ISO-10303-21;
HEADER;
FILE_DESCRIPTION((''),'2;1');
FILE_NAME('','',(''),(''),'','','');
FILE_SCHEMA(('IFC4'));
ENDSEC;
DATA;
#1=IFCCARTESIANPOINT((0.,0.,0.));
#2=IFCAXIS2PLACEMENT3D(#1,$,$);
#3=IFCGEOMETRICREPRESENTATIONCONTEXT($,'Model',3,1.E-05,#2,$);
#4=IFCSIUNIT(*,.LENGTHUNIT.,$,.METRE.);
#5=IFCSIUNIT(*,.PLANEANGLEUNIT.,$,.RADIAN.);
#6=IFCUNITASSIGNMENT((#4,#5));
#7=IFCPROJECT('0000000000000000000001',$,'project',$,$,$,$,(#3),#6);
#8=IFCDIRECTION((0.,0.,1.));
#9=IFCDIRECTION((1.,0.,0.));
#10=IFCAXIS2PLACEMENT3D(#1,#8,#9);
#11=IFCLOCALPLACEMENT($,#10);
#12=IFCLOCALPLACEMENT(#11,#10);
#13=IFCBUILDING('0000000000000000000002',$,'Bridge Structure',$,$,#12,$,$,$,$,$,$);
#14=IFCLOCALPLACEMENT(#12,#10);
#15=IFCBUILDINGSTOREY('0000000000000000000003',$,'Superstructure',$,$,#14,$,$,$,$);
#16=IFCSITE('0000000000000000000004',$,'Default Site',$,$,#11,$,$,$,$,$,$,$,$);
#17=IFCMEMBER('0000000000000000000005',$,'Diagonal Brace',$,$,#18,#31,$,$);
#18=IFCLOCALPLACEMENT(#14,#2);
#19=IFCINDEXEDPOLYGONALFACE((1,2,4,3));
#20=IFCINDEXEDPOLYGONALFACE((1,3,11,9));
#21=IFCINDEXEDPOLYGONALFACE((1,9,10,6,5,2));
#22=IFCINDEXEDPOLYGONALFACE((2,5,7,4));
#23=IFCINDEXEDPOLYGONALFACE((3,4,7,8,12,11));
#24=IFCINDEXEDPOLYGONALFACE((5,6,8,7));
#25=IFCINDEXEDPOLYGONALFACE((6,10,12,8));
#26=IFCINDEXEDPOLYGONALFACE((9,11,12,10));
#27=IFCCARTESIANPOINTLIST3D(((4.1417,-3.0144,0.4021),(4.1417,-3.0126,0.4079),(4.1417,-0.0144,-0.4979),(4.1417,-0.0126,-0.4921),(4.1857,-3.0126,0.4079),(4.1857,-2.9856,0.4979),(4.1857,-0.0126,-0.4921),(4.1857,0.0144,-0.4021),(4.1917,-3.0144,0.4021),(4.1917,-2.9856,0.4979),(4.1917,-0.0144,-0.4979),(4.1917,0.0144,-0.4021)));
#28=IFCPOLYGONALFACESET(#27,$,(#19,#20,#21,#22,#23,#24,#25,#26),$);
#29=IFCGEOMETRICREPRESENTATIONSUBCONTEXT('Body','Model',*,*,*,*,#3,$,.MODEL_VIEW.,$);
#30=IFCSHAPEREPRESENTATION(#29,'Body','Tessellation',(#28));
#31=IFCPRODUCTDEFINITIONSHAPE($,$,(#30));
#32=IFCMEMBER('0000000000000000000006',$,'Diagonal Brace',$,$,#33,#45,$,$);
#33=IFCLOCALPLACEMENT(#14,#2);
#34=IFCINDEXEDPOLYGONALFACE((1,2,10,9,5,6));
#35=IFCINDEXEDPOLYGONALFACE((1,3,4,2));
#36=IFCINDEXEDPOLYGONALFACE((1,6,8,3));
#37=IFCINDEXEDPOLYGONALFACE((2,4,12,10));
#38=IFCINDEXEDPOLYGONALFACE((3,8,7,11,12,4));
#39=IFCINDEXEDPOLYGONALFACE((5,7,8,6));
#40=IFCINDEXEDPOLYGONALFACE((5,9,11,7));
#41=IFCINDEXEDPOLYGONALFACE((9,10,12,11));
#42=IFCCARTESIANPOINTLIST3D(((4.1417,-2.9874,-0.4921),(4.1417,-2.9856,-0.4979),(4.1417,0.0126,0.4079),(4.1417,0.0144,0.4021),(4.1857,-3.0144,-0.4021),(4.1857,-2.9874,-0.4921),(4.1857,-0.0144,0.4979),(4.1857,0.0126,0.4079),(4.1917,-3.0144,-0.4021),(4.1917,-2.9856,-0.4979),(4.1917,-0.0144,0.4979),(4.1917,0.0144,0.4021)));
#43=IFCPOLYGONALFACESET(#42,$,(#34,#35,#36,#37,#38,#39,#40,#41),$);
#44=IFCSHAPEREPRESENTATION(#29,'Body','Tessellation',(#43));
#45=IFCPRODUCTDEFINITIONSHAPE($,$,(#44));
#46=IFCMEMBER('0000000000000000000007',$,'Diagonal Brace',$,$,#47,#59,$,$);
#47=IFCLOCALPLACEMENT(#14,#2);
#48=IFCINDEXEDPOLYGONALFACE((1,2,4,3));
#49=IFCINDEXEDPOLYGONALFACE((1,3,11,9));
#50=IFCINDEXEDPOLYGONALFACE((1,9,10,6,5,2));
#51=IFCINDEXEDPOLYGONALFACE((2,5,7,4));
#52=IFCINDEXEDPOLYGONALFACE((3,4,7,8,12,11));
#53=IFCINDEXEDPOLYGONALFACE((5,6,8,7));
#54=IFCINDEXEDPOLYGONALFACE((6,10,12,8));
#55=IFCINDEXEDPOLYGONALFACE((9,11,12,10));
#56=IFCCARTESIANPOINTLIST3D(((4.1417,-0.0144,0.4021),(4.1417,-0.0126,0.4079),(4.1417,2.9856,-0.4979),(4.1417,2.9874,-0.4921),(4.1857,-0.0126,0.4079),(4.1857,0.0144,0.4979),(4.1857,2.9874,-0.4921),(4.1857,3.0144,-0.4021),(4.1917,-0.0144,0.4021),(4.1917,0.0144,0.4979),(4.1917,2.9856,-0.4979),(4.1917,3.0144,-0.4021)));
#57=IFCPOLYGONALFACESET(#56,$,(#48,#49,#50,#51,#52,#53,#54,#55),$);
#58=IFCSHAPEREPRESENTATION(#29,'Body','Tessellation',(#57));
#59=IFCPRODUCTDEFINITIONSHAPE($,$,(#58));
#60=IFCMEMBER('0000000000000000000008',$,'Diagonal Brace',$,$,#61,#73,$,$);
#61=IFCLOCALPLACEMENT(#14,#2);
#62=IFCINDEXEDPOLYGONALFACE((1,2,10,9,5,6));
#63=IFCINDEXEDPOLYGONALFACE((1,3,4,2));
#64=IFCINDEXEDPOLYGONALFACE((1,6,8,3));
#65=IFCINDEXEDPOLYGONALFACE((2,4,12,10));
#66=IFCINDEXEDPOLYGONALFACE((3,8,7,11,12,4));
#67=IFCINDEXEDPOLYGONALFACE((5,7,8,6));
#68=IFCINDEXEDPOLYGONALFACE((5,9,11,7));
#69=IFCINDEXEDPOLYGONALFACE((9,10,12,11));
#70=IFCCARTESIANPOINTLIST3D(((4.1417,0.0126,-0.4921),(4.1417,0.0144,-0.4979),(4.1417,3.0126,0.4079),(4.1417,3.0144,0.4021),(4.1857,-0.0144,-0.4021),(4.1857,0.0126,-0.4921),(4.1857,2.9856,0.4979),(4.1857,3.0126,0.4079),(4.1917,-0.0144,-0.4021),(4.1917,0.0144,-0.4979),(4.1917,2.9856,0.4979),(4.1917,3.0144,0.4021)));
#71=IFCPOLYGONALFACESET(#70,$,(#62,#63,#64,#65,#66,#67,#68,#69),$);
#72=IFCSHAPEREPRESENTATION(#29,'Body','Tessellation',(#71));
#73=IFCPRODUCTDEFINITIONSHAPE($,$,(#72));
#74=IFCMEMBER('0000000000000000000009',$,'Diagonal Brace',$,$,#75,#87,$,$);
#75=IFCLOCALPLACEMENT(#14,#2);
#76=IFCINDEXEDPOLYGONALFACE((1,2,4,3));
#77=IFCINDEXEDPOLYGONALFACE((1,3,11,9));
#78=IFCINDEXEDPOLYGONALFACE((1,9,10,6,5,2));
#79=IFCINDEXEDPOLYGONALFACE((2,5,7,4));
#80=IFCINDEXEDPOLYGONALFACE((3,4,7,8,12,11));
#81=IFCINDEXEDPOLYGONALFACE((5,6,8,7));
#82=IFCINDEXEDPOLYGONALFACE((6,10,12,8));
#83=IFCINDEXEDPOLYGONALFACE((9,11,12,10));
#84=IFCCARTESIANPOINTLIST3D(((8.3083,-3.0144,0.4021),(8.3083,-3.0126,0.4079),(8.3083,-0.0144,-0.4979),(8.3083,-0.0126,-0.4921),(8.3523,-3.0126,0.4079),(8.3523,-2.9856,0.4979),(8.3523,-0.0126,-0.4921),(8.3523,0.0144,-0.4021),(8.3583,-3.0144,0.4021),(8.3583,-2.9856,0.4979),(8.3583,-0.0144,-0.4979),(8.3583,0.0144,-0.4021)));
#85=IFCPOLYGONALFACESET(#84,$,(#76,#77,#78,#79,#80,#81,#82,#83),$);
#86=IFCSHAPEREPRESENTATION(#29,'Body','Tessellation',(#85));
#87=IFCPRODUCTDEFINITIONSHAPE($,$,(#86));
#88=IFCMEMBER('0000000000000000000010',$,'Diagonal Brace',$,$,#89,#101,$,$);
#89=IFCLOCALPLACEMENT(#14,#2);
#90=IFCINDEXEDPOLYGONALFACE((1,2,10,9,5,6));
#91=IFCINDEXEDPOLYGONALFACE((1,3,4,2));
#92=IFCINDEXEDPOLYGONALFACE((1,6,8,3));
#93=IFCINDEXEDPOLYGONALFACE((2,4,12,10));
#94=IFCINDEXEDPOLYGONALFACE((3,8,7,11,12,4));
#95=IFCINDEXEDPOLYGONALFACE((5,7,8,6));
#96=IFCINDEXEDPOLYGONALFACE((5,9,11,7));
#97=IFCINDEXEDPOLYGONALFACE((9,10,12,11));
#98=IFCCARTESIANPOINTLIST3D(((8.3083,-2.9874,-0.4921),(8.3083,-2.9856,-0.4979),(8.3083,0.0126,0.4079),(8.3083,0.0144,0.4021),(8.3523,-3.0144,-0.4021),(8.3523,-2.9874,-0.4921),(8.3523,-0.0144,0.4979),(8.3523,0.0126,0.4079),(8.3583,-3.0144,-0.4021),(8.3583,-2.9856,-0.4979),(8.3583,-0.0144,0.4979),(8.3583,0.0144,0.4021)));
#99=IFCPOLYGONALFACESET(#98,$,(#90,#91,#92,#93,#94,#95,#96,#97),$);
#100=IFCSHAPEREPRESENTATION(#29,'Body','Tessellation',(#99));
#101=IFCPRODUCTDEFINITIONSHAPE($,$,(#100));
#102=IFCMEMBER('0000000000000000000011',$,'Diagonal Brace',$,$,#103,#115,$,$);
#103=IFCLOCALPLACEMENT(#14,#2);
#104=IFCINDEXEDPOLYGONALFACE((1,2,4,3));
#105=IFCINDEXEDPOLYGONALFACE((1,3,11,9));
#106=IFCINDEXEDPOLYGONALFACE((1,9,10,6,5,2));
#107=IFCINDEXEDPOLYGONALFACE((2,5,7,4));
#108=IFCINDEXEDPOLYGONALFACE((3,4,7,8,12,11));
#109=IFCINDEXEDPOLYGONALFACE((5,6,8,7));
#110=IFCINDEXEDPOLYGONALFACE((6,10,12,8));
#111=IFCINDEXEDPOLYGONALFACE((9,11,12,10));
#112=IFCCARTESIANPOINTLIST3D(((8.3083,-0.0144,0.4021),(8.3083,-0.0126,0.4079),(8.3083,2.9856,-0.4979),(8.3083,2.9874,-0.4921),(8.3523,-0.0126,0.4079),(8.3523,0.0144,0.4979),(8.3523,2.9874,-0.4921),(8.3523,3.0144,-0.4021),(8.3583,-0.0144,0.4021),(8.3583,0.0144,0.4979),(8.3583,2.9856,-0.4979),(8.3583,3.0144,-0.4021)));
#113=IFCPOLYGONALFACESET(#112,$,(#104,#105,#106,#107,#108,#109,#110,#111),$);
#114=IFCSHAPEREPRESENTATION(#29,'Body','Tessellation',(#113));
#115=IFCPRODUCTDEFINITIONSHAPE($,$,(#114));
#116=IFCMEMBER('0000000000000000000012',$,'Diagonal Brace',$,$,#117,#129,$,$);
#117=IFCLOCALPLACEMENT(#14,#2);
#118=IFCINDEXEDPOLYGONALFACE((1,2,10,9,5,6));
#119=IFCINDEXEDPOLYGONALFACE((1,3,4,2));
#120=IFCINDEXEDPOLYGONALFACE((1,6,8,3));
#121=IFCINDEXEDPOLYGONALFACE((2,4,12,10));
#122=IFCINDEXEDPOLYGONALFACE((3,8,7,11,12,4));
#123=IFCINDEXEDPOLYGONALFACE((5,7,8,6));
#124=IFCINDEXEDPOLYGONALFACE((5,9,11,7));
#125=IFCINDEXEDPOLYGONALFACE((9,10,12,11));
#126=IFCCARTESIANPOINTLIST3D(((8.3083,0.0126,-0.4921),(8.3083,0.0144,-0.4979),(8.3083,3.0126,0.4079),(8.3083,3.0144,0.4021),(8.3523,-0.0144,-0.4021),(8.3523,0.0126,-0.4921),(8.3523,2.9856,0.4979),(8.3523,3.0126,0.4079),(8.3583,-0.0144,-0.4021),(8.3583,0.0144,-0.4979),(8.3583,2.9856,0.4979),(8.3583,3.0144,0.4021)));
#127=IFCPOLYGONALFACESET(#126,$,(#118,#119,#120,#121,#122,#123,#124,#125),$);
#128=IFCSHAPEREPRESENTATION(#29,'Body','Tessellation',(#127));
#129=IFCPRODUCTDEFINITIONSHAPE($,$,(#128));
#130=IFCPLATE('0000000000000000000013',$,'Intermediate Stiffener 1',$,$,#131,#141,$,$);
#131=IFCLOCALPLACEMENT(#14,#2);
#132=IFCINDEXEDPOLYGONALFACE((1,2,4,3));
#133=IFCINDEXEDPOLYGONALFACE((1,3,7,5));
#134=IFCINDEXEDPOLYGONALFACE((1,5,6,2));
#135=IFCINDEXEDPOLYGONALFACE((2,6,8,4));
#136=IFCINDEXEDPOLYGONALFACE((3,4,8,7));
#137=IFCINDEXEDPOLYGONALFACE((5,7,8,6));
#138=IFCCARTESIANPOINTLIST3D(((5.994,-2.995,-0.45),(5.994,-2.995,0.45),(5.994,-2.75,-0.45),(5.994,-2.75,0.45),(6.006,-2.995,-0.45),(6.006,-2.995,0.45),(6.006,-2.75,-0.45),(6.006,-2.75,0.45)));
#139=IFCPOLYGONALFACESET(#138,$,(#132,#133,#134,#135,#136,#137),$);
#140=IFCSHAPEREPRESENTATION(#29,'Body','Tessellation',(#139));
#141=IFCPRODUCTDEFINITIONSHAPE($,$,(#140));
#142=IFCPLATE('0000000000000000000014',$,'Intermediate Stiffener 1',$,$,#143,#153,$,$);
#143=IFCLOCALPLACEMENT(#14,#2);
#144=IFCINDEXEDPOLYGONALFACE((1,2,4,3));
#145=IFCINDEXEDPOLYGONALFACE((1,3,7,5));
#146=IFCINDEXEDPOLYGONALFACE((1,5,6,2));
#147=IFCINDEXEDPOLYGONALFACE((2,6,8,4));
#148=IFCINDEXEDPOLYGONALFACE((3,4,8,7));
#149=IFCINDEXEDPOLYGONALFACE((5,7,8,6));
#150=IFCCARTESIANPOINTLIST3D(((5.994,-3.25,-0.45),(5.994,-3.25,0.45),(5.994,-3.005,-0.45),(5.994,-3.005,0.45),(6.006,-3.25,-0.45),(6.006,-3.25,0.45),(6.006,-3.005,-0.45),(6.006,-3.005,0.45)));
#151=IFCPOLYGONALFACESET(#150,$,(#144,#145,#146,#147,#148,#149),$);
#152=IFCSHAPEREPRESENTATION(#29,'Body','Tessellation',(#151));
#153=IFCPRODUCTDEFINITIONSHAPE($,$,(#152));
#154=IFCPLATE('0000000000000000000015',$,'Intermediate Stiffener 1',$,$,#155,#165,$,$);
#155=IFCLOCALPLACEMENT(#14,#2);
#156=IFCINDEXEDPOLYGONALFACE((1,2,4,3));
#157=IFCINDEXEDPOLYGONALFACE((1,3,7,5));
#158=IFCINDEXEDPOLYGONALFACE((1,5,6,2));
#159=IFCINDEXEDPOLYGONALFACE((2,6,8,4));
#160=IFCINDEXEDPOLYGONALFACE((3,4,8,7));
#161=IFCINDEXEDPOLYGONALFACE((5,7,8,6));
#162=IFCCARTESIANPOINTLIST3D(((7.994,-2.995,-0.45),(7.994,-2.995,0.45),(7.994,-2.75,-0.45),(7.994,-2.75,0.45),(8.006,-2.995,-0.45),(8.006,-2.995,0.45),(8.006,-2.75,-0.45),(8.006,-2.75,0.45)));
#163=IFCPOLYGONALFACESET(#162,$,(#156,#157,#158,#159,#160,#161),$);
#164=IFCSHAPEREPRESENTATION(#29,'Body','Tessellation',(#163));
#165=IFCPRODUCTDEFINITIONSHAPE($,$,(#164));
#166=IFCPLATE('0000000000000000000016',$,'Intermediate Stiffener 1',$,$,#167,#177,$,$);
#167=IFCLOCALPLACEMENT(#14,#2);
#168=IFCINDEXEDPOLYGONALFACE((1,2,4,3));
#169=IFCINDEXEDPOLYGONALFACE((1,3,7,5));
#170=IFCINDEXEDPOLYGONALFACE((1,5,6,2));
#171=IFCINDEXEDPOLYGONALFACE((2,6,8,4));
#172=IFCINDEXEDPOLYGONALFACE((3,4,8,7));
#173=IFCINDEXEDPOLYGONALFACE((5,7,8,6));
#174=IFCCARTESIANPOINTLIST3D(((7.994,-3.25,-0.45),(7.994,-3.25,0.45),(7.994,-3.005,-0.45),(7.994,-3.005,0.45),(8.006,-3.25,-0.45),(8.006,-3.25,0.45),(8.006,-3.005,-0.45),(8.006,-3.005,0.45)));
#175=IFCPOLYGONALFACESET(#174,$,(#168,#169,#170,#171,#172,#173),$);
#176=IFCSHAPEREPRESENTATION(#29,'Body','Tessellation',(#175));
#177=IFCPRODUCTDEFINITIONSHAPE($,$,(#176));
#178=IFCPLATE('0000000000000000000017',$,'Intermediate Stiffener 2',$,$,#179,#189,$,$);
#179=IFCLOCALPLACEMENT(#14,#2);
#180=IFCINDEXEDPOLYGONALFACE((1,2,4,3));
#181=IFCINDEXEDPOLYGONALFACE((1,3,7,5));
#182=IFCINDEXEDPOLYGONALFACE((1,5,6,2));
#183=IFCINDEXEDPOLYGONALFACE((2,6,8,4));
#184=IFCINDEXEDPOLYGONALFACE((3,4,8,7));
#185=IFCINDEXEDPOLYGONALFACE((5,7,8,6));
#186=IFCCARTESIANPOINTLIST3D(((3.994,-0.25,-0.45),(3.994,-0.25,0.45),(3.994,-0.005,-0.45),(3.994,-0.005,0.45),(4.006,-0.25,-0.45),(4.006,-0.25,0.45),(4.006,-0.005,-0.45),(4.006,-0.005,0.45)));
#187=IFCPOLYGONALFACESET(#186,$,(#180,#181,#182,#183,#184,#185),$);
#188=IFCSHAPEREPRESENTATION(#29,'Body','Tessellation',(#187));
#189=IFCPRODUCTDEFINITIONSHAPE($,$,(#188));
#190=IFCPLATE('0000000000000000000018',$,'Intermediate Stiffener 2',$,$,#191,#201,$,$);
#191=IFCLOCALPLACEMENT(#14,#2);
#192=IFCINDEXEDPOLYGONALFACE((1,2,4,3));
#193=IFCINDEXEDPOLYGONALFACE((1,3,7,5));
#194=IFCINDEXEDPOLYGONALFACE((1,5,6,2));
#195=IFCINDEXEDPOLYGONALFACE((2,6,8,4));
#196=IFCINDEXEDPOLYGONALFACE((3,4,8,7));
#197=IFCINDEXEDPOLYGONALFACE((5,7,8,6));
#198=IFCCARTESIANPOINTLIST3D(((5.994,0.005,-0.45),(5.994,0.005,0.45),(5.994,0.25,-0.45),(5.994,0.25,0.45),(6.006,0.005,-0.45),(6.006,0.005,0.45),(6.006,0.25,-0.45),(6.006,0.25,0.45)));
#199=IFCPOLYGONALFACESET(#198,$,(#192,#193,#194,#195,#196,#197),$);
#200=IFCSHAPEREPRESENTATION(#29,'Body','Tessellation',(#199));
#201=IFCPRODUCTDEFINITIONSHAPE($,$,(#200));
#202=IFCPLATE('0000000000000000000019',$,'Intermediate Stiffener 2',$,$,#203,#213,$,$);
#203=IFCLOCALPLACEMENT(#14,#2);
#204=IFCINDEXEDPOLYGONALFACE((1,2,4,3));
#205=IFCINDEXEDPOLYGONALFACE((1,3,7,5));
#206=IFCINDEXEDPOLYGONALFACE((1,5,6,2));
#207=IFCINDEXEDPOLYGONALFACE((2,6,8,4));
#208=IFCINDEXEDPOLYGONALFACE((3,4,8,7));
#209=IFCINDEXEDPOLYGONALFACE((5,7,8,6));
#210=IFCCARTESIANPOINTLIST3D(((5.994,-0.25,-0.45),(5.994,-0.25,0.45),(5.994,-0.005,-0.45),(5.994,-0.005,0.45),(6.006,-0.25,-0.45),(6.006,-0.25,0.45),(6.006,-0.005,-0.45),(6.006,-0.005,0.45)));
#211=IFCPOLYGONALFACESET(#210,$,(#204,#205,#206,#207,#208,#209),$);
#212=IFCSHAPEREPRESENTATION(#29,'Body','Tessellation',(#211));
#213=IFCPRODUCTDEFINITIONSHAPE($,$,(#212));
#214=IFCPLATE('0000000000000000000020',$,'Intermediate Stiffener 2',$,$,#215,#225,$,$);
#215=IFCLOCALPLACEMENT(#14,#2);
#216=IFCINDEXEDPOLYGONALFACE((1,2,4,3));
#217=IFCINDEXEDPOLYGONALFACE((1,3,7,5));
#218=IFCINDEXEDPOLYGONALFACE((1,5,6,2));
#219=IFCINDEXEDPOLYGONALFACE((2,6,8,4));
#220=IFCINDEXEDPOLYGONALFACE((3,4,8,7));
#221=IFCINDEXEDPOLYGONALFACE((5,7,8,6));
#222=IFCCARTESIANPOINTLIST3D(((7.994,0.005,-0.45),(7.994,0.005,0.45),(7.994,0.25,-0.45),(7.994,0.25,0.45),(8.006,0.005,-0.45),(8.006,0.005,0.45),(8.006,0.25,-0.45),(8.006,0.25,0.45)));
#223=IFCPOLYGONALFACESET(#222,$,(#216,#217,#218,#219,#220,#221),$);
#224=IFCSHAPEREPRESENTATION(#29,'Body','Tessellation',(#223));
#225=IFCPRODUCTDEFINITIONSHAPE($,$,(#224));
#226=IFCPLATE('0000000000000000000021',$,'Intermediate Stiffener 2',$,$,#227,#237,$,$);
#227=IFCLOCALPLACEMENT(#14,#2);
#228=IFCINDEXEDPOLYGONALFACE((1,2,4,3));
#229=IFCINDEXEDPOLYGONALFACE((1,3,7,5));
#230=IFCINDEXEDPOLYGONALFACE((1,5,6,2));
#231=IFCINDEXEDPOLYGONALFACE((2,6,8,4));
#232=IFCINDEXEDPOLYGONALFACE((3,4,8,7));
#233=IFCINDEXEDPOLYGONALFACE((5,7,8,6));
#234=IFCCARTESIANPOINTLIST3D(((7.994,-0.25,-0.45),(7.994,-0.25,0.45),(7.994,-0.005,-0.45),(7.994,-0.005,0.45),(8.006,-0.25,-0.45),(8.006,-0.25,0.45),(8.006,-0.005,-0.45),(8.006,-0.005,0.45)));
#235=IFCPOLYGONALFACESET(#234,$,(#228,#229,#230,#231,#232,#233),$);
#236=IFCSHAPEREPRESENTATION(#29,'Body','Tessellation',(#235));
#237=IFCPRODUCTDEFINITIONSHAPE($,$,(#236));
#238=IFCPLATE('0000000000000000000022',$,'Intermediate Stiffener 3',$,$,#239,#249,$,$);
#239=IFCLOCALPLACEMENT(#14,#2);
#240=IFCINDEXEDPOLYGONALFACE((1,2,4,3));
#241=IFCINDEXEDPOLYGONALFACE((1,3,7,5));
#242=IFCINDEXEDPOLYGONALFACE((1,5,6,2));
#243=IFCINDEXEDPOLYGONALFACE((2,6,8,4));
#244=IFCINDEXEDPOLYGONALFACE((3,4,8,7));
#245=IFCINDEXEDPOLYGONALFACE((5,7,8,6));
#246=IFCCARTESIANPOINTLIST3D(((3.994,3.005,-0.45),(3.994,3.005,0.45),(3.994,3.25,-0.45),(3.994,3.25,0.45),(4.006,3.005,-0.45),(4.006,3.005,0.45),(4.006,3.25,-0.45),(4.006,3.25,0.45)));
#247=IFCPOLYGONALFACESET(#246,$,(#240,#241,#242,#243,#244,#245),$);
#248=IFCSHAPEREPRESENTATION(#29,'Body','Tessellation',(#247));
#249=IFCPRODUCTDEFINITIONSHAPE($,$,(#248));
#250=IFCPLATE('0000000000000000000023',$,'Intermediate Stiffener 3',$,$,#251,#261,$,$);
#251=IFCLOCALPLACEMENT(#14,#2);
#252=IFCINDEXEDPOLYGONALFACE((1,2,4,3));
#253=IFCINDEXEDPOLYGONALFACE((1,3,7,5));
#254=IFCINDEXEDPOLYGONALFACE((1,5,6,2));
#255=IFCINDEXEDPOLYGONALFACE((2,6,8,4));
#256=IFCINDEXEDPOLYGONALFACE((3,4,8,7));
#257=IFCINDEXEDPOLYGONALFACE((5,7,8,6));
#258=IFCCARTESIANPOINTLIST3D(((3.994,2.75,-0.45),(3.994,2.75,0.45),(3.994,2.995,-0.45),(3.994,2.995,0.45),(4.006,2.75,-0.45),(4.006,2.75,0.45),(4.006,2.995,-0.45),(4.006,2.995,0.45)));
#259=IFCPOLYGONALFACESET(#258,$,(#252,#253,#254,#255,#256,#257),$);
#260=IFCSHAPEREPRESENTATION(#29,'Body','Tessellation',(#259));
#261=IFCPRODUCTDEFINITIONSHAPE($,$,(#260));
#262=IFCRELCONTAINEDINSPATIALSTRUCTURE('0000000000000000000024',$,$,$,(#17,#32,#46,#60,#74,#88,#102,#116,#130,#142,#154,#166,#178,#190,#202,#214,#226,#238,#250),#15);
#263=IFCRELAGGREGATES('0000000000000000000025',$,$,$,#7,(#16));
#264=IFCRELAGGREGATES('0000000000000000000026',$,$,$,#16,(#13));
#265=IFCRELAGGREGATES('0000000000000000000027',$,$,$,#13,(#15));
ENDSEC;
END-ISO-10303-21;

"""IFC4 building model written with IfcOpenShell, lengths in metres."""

from ifc_helpers import new_model, si_unit, frame, origin, origin_with_axes, origin_2d_with_axis, place, context, subcontext, project, spatial, rectangle, l_section, extrude, element, save


model = new_model("IFC4")

# Units and contexts
model_context = context("Model", 3, precision=1e-05, world=origin())
body_context = subcontext(model_context, "Body", "Model", "MODEL_VIEW")
ifc_project = project(units=[si_unit("LENGTHUNIT", "METRE"), si_unit("PLANEANGLEUNIT", "RADIAN")], contexts=[model_context])

# Site, building, storey
site_placement = place(None, origin_with_axes())
site = spatial("IfcSite", under=ifc_project, at=site_placement, Name="Default Site")
building_placement = place(site_placement, origin_with_axes())
building = spatial("IfcBuilding", under=site, at=building_placement, Name="Bridge Structure")
storey_placement = place(building_placement, origin_with_axes())
storey = spatial("IfcBuildingStorey", under=building, at=storey_placement, Name="Superstructure")

# Members
for number, where, z_axis, x_axis, name in (
    (1, (4.1667, -3.0, 0.45), (0.0, 0.957826, -0.287348), (-1.0, 0.0, 0.0), "Diagonal Brace"),
    (2, (4.1667, -3.0, -0.45), (0.0, 0.957826, 0.287348), (-1.0, 0.0, 0.0), "Diagonal Brace"),
    (3, (4.1667, 0.0, 0.45), (0.0, 0.957826, -0.287348), (-1.0, 0.0, 0.0), "Diagonal Brace"),
    (4, (4.1667, 0.0, -0.45), (0.0, 0.957826, 0.287348), (-1.0, 0.0, 0.0), "Diagonal Brace"),
    (5, (8.3333, -3.0, 0.45), (0.0, 0.957826, -0.287348), (-1.0, 0.0, 0.0), "Diagonal Brace"),
    (6, (8.3333, -3.0, -0.45), (0.0, 0.957826, 0.287348), (-1.0, 0.0, 0.0), "Diagonal Brace"),
    (7, (8.3333, 0.0, 0.45), (0.0, 0.957826, -0.287348), (-1.0, 0.0, 0.0), "Diagonal Brace"),
    (8, (8.3333, 0.0, -0.45), (0.0, 0.957826, 0.287348), (-1.0, 0.0, 0.0), "Diagonal Brace"),
):
    element("IfcMember", number, at=place(storey_placement, frame(where, z_axis=z_axis, x_axis=x_axis)), inside=storey, Name=name, context=body_context, shape_type="SweptSolid", body=[
        extrude(l_section(Depth=0.1, Width=0.05, Thickness=0.006, at=origin_2d_with_axis()), origin_with_axes(), (0.0, 0.0, 1.0), 3.1321),
    ])

# Plates
for number, where, z_axis, x_axis, name in (
    (9, (6.0, -2.8725, -0.45), (0.0, 0.0, 1.0), (1.0, 0.0, 0.0), "Intermediate Stiffener 1"),
    (10, (6.0, -3.1275, -0.45), (0.0, 0.0, 1.0), (1.0, 0.0, 0.0), "Intermediate Stiffener 1"),
    (11, (8.0, -2.8725, -0.45), (0.0, 0.0, 1.0), (1.0, 0.0, 0.0), "Intermediate Stiffener 1"),
    (12, (8.0, -3.1275, -0.45), (0.0, 0.0, 1.0), (1.0, 0.0, 0.0), "Intermediate Stiffener 1"),
    (13, (4.0, -0.1275, -0.45), (0.0, 0.0, 1.0), (1.0, 0.0, 0.0), "Intermediate Stiffener 2"),
    (14, (6.0, 0.1275, -0.45), (0.0, 0.0, 1.0), (1.0, 0.0, 0.0), "Intermediate Stiffener 2"),
    (15, (6.0, -0.1275, -0.45), (0.0, 0.0, 1.0), (1.0, 0.0, 0.0), "Intermediate Stiffener 2"),
    (16, (8.0, 0.1275, -0.45), (0.0, 0.0, 1.0), (1.0, 0.0, 0.0), "Intermediate Stiffener 2"),
    (17, (8.0, -0.1275, -0.45), (0.0, 0.0, 1.0), (1.0, 0.0, 0.0), "Intermediate Stiffener 2"),
    (18, (4.0, 3.1275, -0.45), (0.0, 0.0, 1.0), (1.0, 0.0, 0.0), "Intermediate Stiffener 3"),
    (19, (4.0, 2.8725, -0.45), (0.0, 0.0, 1.0), (1.0, 0.0, 0.0), "Intermediate Stiffener 3"),
):
    element("IfcPlate", number, at=place(storey_placement, frame(where, z_axis=z_axis, x_axis=x_axis)), inside=storey, Name=name, context=body_context, shape_type="SweptSolid", body=[
        extrude(rectangle(XDim=0.012, YDim=0.245, at=origin_2d_with_axis()), origin_with_axes(), (0.0, 0.0, 1.0), 0.9),
    ])

save(model, "model.ifc")
